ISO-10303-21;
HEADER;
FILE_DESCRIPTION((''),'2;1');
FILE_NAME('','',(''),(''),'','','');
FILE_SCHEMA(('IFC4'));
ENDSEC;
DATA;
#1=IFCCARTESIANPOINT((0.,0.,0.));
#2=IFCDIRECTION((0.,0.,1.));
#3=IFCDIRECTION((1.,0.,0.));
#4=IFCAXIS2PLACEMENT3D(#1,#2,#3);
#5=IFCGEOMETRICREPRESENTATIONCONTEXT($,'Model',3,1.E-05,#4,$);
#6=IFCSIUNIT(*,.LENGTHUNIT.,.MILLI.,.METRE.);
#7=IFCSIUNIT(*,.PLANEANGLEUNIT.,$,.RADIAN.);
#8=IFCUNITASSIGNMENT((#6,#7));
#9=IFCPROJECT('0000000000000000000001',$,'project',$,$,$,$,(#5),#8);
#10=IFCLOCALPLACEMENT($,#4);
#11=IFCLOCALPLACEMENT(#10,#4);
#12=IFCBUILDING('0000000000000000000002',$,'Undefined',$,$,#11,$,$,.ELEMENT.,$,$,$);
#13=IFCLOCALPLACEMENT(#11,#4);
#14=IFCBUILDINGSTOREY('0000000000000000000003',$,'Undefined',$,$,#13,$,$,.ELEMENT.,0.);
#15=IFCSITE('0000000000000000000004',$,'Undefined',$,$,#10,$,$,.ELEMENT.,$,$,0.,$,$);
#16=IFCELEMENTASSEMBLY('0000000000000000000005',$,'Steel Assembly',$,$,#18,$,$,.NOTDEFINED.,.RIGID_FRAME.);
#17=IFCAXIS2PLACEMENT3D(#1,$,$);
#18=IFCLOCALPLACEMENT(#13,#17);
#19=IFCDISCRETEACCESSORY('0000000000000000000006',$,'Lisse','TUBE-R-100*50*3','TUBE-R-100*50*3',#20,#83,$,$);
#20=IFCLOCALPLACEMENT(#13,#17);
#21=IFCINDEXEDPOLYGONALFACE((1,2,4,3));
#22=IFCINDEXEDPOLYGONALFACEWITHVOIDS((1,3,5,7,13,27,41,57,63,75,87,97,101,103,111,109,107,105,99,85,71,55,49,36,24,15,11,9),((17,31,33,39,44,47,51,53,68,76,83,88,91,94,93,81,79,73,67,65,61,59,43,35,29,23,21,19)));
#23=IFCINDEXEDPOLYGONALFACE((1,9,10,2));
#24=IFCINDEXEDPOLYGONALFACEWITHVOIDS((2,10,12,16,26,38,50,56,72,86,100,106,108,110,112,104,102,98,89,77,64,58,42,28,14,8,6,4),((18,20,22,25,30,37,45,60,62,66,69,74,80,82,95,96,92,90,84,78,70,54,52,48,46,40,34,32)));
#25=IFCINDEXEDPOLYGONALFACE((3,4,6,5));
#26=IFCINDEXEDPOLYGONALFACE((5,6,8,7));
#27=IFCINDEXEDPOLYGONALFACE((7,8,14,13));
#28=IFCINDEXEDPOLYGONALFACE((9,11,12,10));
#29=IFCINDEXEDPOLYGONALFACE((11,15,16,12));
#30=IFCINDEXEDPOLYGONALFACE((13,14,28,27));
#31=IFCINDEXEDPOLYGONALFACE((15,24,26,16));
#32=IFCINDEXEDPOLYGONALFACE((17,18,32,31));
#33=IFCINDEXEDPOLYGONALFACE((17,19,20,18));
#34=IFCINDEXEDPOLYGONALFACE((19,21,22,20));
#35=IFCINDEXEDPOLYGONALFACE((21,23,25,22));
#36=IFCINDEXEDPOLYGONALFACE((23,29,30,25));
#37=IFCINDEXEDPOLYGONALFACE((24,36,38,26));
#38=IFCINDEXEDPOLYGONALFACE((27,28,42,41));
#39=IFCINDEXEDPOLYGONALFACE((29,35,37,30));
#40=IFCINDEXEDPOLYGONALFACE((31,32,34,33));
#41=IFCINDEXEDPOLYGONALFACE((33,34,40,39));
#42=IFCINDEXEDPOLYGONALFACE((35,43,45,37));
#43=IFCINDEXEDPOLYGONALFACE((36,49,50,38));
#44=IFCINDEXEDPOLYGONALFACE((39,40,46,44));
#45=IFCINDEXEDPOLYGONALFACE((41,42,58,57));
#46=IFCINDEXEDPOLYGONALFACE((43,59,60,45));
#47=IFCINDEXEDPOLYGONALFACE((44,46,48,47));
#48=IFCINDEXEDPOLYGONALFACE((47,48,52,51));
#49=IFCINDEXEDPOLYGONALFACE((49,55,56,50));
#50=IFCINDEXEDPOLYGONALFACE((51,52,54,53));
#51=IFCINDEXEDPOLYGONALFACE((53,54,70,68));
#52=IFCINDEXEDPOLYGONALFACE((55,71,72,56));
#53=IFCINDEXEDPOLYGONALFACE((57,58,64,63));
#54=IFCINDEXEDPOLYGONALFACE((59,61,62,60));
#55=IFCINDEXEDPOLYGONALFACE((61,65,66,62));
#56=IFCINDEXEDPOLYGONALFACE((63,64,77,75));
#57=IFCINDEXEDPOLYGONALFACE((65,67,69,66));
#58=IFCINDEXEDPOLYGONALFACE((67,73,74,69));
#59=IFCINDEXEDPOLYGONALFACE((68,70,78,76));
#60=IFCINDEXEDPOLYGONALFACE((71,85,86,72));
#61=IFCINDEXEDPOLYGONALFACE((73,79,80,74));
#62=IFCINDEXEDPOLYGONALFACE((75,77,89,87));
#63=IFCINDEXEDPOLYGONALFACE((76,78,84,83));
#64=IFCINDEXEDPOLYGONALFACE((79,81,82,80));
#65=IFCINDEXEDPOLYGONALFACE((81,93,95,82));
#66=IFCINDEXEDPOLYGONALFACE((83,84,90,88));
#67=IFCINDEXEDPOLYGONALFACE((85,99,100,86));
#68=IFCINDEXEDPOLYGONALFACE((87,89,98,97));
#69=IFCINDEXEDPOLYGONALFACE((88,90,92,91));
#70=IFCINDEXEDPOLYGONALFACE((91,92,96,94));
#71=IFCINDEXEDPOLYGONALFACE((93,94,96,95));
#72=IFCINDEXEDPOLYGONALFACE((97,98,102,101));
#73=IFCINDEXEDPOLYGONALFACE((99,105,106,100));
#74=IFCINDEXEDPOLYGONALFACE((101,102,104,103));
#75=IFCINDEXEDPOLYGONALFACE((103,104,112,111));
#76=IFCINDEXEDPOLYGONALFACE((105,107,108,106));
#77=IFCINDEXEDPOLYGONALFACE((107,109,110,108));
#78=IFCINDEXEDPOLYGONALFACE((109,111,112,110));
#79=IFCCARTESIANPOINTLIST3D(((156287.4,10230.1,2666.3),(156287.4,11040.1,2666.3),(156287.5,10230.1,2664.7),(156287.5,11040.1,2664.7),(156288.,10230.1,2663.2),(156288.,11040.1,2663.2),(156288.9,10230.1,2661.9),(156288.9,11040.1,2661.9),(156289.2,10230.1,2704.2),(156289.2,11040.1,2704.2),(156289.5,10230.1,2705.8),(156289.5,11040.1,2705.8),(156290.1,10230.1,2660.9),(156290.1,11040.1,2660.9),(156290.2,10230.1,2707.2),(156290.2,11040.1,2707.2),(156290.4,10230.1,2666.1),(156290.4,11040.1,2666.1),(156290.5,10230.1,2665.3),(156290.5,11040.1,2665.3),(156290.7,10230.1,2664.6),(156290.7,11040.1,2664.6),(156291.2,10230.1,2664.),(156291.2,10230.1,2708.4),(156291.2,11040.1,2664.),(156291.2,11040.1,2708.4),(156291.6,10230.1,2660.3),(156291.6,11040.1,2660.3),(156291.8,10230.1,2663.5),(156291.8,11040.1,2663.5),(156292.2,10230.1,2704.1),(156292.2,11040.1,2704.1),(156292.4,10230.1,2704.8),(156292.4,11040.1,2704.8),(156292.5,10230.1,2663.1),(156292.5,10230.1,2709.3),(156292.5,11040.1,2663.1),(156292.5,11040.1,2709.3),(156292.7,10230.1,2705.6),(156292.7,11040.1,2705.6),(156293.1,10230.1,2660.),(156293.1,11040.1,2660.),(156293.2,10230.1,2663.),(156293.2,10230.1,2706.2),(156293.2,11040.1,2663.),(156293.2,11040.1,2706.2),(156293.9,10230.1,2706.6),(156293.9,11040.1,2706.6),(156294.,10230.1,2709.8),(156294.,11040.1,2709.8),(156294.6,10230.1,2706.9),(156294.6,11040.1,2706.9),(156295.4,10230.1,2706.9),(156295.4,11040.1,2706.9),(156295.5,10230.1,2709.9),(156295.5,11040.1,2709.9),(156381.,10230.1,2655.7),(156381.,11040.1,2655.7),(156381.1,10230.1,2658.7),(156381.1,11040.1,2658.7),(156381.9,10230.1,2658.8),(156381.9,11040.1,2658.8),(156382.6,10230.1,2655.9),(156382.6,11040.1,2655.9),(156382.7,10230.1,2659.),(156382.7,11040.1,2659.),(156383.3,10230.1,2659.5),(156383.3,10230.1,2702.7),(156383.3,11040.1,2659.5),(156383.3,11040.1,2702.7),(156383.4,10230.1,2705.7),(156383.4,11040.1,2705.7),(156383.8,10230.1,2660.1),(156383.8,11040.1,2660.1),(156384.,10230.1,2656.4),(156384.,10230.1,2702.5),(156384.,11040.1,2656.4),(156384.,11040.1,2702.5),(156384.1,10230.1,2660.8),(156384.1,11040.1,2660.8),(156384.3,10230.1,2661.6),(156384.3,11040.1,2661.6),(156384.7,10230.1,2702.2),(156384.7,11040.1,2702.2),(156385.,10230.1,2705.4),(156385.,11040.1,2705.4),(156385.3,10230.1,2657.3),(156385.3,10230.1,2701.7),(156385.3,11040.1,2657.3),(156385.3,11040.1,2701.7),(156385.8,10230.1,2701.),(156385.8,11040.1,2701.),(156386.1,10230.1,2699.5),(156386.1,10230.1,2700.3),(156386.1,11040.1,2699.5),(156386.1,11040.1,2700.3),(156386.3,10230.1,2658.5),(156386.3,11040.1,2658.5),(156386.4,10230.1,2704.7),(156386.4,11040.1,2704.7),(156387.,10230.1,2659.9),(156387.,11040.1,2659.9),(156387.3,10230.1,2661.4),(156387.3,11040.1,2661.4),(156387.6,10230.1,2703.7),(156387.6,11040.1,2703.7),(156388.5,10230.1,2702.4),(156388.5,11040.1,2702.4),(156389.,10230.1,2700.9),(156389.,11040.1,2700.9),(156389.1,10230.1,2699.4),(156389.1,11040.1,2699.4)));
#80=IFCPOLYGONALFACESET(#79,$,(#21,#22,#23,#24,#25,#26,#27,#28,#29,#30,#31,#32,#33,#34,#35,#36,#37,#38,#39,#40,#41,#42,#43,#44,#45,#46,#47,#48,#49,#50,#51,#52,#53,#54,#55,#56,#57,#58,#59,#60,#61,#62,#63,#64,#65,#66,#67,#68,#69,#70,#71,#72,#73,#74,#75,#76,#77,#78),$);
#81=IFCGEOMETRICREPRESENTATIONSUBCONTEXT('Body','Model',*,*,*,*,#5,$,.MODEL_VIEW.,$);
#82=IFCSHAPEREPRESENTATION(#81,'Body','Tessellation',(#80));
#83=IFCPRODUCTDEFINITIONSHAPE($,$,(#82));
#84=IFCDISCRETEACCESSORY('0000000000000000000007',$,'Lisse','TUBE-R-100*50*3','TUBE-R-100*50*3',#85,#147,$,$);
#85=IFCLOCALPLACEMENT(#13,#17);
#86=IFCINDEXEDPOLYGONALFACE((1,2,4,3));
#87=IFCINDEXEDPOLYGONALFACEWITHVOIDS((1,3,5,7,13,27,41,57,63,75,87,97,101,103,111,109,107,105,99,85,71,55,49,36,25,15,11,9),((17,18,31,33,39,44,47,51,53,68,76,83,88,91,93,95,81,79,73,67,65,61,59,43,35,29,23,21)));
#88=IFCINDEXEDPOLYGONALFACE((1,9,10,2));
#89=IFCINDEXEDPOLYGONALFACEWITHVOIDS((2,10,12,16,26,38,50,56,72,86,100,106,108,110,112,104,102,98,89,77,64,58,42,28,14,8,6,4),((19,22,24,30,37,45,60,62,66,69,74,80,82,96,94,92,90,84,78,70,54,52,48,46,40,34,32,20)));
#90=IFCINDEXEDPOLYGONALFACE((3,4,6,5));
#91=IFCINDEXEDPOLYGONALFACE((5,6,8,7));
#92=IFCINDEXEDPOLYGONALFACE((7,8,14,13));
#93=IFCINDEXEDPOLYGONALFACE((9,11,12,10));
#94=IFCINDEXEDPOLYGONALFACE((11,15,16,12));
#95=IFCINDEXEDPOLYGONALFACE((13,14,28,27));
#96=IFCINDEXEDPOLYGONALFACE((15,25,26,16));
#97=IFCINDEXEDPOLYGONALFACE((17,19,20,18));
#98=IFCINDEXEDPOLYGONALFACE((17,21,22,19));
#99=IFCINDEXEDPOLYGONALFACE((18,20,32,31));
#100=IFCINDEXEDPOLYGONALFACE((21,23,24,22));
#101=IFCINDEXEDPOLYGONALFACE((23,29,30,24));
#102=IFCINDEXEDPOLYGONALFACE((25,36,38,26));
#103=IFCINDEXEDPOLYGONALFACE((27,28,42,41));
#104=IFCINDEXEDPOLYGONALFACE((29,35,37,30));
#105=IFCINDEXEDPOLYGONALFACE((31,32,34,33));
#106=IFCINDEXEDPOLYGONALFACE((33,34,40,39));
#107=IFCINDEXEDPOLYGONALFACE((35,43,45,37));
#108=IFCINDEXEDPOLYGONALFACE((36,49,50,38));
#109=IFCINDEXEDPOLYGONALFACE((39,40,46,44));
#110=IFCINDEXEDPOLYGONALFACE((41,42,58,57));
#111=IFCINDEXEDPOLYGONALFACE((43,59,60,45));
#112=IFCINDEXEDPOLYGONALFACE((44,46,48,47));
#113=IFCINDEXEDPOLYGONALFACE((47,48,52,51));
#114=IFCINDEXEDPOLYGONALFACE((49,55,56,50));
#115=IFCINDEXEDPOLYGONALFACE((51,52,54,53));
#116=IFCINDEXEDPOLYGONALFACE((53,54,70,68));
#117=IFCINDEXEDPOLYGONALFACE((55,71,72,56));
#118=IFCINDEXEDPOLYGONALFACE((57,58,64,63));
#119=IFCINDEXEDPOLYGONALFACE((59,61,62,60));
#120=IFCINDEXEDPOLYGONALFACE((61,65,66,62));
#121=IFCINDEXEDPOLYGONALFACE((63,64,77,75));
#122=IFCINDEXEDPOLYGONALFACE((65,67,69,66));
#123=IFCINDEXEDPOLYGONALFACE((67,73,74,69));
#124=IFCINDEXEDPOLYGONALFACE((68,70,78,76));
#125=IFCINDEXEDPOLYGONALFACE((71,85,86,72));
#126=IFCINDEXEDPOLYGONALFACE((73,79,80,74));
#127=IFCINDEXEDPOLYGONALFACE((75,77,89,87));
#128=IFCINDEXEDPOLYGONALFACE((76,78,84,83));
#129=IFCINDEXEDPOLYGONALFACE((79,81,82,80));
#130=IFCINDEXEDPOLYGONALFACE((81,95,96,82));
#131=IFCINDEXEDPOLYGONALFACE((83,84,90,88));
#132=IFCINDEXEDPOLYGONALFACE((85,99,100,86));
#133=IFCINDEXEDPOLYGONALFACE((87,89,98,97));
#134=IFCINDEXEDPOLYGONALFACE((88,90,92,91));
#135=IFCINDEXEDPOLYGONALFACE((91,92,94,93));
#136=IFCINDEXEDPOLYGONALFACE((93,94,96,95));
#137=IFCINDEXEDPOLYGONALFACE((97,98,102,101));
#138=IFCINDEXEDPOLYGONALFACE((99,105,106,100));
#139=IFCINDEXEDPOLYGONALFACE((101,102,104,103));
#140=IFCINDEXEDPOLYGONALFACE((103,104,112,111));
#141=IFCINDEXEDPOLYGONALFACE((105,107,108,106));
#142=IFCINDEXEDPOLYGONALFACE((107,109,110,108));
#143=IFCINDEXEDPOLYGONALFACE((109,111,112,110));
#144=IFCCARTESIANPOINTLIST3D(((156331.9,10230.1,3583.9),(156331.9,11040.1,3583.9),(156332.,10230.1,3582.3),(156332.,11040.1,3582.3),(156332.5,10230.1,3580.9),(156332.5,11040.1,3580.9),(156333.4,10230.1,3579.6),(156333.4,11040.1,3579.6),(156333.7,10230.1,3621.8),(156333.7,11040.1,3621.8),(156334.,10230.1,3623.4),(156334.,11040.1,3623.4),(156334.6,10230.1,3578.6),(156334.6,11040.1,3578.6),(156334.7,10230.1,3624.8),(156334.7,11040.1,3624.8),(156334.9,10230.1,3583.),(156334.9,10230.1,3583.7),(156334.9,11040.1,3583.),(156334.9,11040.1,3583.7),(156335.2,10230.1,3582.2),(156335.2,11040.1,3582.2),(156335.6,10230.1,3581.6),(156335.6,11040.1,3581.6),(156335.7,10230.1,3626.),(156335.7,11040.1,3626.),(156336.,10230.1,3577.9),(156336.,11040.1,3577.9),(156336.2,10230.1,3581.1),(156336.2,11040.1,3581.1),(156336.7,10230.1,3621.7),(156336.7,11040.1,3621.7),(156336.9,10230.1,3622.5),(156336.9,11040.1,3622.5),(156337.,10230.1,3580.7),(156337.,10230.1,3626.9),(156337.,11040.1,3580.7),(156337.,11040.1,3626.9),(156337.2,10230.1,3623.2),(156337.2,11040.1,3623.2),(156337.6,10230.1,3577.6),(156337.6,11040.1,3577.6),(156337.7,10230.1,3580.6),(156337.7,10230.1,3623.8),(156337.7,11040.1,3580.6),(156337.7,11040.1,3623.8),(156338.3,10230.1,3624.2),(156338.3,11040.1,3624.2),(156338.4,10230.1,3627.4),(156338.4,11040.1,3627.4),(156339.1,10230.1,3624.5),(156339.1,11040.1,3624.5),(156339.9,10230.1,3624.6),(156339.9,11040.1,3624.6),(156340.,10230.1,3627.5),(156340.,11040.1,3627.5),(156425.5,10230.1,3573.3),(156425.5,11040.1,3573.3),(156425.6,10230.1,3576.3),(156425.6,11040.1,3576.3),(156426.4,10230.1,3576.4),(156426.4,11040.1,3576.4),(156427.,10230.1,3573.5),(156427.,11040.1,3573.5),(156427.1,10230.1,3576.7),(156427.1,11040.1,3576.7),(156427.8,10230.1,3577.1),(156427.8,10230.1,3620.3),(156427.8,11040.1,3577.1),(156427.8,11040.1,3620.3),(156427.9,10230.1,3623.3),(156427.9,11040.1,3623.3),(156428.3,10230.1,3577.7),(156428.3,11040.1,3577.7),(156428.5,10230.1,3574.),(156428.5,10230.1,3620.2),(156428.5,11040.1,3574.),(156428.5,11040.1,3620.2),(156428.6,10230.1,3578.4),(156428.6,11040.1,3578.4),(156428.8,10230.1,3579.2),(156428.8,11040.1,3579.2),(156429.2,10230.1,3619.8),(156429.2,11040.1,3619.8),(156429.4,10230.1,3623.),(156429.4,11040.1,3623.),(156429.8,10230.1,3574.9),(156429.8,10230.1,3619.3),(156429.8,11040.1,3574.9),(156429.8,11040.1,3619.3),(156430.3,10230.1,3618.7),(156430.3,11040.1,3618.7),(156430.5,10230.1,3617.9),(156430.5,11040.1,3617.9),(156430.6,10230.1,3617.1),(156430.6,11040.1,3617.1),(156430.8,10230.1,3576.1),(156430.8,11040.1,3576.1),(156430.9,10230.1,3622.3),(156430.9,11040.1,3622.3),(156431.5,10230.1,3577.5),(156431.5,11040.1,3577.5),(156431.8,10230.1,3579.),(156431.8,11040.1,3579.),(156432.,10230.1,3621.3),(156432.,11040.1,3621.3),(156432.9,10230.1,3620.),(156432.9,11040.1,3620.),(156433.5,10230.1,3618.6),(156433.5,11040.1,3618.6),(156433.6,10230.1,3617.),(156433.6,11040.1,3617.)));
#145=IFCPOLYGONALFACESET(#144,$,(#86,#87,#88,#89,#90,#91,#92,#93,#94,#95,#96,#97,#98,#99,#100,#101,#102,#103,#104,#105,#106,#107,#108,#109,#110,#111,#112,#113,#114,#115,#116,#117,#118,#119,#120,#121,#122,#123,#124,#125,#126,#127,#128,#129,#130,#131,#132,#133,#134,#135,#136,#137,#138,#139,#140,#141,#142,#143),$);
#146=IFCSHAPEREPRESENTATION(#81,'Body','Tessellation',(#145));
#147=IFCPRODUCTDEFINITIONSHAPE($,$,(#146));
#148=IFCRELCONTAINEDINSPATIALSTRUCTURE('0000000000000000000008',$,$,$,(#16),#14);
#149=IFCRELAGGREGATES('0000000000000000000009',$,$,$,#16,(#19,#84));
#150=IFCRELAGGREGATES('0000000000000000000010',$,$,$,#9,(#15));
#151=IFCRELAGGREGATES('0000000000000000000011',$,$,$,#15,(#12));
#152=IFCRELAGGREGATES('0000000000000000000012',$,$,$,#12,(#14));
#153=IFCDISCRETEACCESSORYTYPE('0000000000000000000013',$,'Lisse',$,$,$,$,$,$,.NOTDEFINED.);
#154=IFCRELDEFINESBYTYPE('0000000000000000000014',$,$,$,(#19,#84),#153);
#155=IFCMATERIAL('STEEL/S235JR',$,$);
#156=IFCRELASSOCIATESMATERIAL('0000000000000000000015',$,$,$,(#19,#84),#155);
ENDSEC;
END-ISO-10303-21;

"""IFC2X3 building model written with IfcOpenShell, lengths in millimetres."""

from ifc_helpers import new_model, si_unit, frame, origin_with_axes, origin_2d_with_axis, place, context, subcontext, project, spatial, hollow_rectangle, extrude, material, type_object, element, aggregate, save


model = new_model("IFC2X3")

# Units and contexts
model_context = context("Model", 3, precision=1e-05, world=origin_with_axes())
body_context = subcontext(model_context, "Body", "Model", "MODEL_VIEW")
ifc_project = project(units=[si_unit("LENGTHUNIT", "METRE", prefix="MILLI"), si_unit("PLANEANGLEUNIT", "RADIAN")], contexts=[model_context])

# Site, building, storey
site_placement = place(None, origin_with_axes())
site = spatial("IfcSite", under=ifc_project, at=site_placement, Name="Undefined", CompositionType="ELEMENT", RefElevation=0.0)
building_placement = place(site_placement, origin_with_axes())
building = spatial("IfcBuilding", under=site, at=building_placement, Name="Undefined", CompositionType="ELEMENT")
storey_placement = place(building_placement, origin_with_axes())
storey = spatial("IfcBuildingStorey", under=building, at=storey_placement, Name="Undefined", CompositionType="ELEMENT", Elevation=0.0)

# Shared definitions
ifc_material_1 = material(Name="STEEL/S235JR")

# Element assembly, discrete accessories
assembly_1_placement = place(storey_placement, origin_with_axes())
assembly_1 = element("IfcElementAssembly", 1, at=assembly_1_placement, inside=storey, Name="Steel Assembly", AssemblyPlace="NOTDEFINED", PredefinedType="RIGID_FRAME")
discrete_accessory_type_1 = type_object("IfcDiscreteAccessoryType", Name="Lisse")
discrete_accessory_1_placement = place(assembly_1_placement, frame((156338.3, 10230.1, 2682.8), z_axis=(-0.998827, 0.0, 0.048423), x_axis=(0.0, 1.0, 0.0)))
discrete_accessory_1 = element("IfcDiscreteAccessory", 2, at=discrete_accessory_1_placement, type_object=discrete_accessory_type_1, material=ifc_material_1, Name="Lisse", Description="TUBE-R-100*50*3", ObjectType="TUBE-R-100*50*3", context=body_context, shape_type="SweptSolid", body=[
    extrude(hollow_rectangle(XDim=50.0, YDim=100.0, WallThickness=3.0, InnerFilletRadius=3.0, OuterFilletRadius=6.0, at=origin_2d_with_axis()), frame((810.0, 0.0, 0.0), z_axis=(-1.0, 0.0, 0.0), x_axis=(0.0, -1.0, 0.0)), (0.0, 0.0, 1.0), 810.0),
])
discrete_accessory_2_placement = place(assembly_1_placement, frame((156382.7, 10230.1, 3600.4), z_axis=(-0.998827, 0.0, 0.048423), x_axis=(0.0, 1.0, 0.0)))
discrete_accessory_2 = element("IfcDiscreteAccessory", 3, at=discrete_accessory_2_placement, type_object=discrete_accessory_type_1, material=ifc_material_1, Name="Lisse", Description="TUBE-R-100*50*3", ObjectType="TUBE-R-100*50*3", context=body_context, shape_type="SweptSolid", body=[
    extrude(hollow_rectangle(XDim=50.0, YDim=100.0, WallThickness=3.0, InnerFilletRadius=3.0, OuterFilletRadius=6.0, at=origin_2d_with_axis()), frame((810.0, 0.0, 0.0), z_axis=(-1.0, 0.0, 0.0), x_axis=(0.0, -1.0, 0.0)), (0.0, 0.0, 1.0), 810.0),
])
aggregate(assembly_1, [discrete_accessory_1, discrete_accessory_2])

save(model, "model.ifc")
